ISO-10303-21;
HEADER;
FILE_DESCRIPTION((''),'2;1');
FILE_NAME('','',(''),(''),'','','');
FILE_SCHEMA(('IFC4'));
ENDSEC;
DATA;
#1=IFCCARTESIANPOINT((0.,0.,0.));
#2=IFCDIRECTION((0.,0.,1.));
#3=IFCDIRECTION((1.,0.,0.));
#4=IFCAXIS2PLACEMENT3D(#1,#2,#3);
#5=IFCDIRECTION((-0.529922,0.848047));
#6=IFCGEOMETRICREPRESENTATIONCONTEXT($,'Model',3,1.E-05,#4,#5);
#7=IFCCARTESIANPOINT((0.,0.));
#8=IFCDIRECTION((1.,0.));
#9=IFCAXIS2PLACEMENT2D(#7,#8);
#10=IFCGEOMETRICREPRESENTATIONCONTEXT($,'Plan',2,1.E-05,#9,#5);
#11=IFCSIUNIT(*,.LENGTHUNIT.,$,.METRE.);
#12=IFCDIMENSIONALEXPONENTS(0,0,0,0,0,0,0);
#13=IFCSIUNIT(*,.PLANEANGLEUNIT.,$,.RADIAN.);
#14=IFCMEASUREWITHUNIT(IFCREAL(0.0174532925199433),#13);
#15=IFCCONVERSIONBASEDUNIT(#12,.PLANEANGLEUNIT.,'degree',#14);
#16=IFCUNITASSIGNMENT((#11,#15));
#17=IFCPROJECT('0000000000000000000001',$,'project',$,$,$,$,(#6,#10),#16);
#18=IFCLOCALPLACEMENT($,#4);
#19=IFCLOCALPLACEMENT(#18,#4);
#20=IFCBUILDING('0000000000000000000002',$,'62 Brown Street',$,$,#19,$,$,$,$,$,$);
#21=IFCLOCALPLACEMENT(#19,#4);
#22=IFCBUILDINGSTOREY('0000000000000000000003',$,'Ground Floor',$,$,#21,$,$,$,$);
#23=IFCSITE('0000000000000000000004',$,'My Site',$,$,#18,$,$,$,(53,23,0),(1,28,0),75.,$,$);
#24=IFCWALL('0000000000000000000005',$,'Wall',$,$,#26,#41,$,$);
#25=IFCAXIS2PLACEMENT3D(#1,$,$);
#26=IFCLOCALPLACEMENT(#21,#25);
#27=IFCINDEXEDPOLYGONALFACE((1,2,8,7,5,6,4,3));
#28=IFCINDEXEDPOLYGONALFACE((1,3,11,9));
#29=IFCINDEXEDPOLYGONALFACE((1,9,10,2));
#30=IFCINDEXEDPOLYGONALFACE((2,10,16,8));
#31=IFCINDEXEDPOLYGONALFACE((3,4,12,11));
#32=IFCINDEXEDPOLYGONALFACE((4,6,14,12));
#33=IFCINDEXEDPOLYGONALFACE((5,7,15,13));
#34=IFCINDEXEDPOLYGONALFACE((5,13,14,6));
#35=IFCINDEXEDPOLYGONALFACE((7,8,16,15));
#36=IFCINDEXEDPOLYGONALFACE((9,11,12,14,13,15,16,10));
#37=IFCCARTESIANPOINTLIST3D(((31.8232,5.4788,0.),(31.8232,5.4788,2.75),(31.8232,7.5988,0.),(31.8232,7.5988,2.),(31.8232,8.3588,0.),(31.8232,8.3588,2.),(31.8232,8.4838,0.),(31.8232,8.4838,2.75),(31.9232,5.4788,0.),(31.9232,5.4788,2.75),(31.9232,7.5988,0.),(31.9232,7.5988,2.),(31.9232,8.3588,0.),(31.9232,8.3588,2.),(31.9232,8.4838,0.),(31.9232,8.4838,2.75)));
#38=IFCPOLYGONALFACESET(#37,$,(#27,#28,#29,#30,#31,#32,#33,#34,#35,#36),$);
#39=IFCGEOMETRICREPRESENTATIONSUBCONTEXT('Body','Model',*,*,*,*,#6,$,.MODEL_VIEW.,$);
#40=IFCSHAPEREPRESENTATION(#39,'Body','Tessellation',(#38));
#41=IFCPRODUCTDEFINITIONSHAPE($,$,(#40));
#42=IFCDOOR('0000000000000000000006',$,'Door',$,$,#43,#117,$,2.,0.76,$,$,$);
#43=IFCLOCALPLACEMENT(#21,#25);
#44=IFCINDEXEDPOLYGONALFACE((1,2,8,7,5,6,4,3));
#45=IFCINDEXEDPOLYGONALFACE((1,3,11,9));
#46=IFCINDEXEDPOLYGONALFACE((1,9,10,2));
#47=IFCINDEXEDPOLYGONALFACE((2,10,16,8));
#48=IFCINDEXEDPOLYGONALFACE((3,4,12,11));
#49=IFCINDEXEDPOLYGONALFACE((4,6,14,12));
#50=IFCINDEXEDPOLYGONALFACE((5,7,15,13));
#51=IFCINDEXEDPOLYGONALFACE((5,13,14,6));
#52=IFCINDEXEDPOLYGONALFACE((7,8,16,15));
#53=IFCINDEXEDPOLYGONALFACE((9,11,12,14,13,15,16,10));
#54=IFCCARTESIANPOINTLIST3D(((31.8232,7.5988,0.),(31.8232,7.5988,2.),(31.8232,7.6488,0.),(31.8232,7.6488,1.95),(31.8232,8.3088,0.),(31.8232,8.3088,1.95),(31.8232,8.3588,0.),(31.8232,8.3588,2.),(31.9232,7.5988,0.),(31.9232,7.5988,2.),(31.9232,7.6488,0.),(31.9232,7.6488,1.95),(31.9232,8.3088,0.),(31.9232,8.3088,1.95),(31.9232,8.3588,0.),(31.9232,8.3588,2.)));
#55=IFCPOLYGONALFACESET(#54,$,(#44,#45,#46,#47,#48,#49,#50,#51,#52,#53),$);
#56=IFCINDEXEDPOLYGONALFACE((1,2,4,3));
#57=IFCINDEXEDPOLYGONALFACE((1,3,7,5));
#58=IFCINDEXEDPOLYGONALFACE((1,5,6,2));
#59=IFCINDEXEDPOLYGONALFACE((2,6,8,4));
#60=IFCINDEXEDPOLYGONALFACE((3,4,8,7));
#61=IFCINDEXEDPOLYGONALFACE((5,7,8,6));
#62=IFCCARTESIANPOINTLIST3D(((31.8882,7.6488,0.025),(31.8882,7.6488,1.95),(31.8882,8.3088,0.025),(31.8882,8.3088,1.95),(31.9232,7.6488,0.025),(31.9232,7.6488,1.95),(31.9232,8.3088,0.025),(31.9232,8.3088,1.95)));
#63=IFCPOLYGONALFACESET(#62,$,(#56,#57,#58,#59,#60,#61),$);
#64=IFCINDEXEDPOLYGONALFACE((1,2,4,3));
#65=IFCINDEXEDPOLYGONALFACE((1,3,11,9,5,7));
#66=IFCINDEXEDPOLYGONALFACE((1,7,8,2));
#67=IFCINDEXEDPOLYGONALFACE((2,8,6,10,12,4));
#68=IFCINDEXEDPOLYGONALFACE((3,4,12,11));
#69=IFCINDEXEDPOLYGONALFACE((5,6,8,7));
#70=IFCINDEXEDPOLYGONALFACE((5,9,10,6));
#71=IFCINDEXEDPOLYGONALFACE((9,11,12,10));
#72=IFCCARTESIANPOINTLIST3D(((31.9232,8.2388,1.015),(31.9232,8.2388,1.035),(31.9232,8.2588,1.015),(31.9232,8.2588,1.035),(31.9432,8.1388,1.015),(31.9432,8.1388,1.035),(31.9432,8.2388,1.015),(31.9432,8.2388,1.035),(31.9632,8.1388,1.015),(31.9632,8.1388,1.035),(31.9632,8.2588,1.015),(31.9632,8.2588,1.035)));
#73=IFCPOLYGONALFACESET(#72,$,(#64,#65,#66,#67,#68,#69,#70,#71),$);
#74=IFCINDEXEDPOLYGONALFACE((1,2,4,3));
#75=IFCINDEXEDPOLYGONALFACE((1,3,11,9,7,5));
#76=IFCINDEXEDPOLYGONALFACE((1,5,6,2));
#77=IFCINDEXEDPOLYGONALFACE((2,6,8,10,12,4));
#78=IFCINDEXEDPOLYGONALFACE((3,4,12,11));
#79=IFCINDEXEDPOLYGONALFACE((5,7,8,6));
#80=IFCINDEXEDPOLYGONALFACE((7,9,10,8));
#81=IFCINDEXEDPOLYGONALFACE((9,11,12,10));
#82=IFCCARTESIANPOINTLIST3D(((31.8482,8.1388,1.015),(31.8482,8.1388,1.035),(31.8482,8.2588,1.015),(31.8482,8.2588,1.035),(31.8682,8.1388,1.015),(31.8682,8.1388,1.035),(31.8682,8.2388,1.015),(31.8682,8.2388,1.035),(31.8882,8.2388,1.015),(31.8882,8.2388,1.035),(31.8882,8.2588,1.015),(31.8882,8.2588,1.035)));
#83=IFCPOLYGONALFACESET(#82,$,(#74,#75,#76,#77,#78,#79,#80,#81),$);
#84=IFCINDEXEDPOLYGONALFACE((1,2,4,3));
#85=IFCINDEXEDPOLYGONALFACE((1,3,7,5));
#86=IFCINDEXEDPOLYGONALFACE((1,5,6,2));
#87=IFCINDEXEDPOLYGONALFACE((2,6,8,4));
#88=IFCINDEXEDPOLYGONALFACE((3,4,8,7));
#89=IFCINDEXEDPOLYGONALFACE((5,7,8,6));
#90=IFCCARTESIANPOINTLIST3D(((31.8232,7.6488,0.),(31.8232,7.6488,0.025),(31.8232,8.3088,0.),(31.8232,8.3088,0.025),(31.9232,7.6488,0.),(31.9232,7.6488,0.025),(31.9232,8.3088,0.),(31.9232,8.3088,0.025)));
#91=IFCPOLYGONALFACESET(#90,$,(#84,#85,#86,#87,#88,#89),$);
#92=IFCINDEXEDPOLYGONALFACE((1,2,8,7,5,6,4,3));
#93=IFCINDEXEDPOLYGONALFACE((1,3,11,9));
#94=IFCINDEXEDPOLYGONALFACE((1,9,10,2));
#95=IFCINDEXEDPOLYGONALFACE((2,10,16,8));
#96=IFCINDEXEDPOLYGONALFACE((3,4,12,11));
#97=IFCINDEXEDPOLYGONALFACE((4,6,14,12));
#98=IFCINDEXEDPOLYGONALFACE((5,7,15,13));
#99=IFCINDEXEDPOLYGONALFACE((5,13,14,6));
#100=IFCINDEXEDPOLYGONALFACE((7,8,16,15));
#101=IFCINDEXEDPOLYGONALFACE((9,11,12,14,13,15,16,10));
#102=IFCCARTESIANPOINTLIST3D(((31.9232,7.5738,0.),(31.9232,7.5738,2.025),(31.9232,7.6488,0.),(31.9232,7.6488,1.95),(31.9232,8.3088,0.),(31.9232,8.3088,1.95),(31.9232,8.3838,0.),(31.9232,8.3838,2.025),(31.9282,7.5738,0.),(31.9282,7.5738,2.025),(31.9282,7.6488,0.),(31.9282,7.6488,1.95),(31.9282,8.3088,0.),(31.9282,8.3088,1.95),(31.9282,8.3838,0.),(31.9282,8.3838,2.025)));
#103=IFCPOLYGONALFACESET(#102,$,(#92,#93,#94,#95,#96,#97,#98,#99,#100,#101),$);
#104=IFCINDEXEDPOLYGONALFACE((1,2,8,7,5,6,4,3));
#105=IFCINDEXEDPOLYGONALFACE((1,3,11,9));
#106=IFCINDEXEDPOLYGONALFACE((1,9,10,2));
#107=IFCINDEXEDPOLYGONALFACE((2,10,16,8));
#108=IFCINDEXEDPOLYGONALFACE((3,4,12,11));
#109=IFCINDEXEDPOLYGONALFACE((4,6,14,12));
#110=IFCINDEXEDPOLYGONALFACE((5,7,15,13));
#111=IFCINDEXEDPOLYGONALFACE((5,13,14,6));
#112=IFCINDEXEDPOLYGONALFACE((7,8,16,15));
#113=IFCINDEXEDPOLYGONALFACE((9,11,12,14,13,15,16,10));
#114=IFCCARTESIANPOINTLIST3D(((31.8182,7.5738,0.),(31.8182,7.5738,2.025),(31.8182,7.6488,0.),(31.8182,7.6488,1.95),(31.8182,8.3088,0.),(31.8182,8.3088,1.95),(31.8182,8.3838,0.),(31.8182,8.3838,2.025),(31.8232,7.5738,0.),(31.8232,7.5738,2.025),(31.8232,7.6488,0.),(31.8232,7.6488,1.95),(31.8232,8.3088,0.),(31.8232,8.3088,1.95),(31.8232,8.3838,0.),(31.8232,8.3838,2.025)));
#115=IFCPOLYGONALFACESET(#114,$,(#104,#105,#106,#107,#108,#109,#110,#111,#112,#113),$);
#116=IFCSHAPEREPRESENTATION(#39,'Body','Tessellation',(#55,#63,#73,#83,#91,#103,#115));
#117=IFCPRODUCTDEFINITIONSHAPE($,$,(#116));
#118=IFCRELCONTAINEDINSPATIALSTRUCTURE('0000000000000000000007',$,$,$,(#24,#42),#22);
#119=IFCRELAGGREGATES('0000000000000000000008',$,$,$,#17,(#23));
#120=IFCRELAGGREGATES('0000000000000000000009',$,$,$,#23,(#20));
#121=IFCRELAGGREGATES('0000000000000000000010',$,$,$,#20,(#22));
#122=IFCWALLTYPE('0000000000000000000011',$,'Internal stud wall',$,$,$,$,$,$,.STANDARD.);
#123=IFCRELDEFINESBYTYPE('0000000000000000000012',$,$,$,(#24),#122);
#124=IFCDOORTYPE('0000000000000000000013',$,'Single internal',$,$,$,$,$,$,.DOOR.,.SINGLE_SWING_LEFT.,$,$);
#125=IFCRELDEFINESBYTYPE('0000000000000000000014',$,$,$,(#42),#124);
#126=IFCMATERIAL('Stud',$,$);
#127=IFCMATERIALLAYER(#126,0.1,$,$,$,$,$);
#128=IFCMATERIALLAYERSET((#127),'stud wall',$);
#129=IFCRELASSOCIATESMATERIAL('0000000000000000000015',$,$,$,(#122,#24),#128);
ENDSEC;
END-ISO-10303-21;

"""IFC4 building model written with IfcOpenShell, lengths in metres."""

from ifc_helpers import new_model, entity, si_unit, converted_unit, direction, frame, origin_with_axes, origin_2d_with_axis, place, context, subcontext, project, spatial, line, indexed_curve, outline, extrude, shape, source, transform, mapped, material, layer, layer_set, layer_usage, type_object, type_shapes, element, fill, save


model = new_model("IFC4")

# Units and contexts
model_context = context("Model", 3, precision=1e-05, world=origin_with_axes(), true_north=direction((-0.529922, 0.848047)))
plan_context = context("Plan", 2, precision=1e-05, world=origin_2d_with_axis(), true_north=direction((-0.529922, 0.848047)))
body_context_1 = subcontext(model_context, "Body", "Model", "MODEL_VIEW")
body_context_2 = subcontext(plan_context, "Body", "Plan", "PLAN_VIEW")
ifc_project = project(units=[si_unit("LENGTHUNIT", "METRE"), converted_unit("PLANEANGLEUNIT", "degree", entity("IfcReal", 0.0174532925199433), si_unit("PLANEANGLEUNIT", "RADIAN"), dimensions=[0, 0, 0, 0, 0, 0, 0])], contexts=[model_context, plan_context])

# Site, building, storey
site_placement = place(None, origin_with_axes())
site = spatial("IfcSite", under=ifc_project, at=site_placement, Name="My Site", RefLatitude=(53, 23, 0), RefLongitude=(1, 28, 0), RefElevation=75.0)
building_placement = place(site_placement, origin_with_axes())
building = spatial("IfcBuilding", under=site, at=building_placement, Name="62 Brown Street")
storey_placement = place(building_placement, origin_with_axes())
storey = spatial("IfcBuildingStorey", under=building, at=storey_placement, Name="Ground Floor")

# Wall, opening, door
ifc_material_1 = material(Name="Stud")
ifc_layer_1 = layer(ifc_material_1, 0.1)
ifc_layer_set_1 = layer_set([ifc_layer_1], Name="stud wall")
wall_type_1 = type_object("IfcWallType", Name="Internal stud wall", PredefinedType="STANDARD", material=ifc_layer_set_1)
shared_shape_1 = source(origin_with_axes(), body_context_1, "Body", "SweptSolid", [
    extrude(outline(indexed_curve([(0.0, 0.0), (0.76, 0.0), (0.76, 2.0), (0.0, 2.0)], segments=[line(1, 2, 3, 4, 1)])), frame((0.0, -0.6, 0.0), z_axis=(0.0, -1.0, 0.0), x_axis=(1.0, 0.0, 0.0)), (0.0, 0.0, -1.0), 1.2),
])
door_type_1 = type_object("IfcDoorType", Name="Single internal", OperationType="SINGLE_SWING_LEFT", PredefinedType="DOOR")
shared_shape_2 = source(origin_with_axes(), body_context_1, "Body", "SweptSolid", [
    extrude(outline(indexed_curve([(0.0, 0.0), (0.0, 2.0), (0.76, 2.0), (0.76, 0.0), (0.71, 0.0), (0.71, 1.95), (0.05, 1.95), (0.05, 0.0)], segments=[line(1, 2, 3, 4, 5, 6, 7, 8, 1)])), frame((0.0, 0.0, 0.0), z_axis=(0.0, -1.0, 0.0), x_axis=(1.0, 0.0, 0.0)), (0.0, 0.0, -1.0), 0.1),
    extrude(outline(indexed_curve([(0.0, 0.0), (0.66, 0.0), (0.66, 0.035), (0.0, 0.035)], segments=[line(1, 2, 3, 4, 1)])), frame((0.05, 0.0, 0.025), z_axis=(0.0, 0.0, 1.0), x_axis=(1.0, 0.0, 0.0)), (0.0, 0.0, 1.0), 1.925),
    extrude(outline(indexed_curve([(0.0, 0.0), (0.0, -0.04), (-0.12, -0.04), (-0.12, -0.02), (-0.02, -0.02), (-0.02, 0.0)], segments=[line(1, 2, 3, 4, 5, 6, 1)])), frame((0.66, 0.0, 1.015), z_axis=(0.0, 0.0, 1.0), x_axis=(1.0, 0.0, 0.0)), (0.0, 0.0, 1.0), 0.02),
    extrude(outline(indexed_curve([(0.0, 0.0), (0.0, 0.04), (-0.12, 0.04), (-0.12, 0.02), (-0.02, 0.02), (-0.02, 0.0)], segments=[line(1, 2, 3, 4, 5, 6, 1)])), frame((0.66, 0.035, 1.015), z_axis=(0.0, 0.0, 1.0), x_axis=(1.0, 0.0, 0.0)), (0.0, 0.0, 1.0), 0.02),
    extrude(outline(indexed_curve([(0.0, 0.0), (0.66, 0.0), (0.66, 0.1), (0.0, 0.1)], segments=[line(1, 2, 3, 4, 1)])), frame((0.05, 0.0, 0.0), z_axis=(0.0, 0.0, 1.0), x_axis=(1.0, 0.0, 0.0)), (0.0, 0.0, 1.0), 0.025),
    extrude(outline(indexed_curve([(0.0, 0.0), (0.0, 2.025), (0.81, 2.025), (0.81, 0.0), (0.735, 0.0), (0.735, 1.95), (0.075, 1.95), (0.075, 0.0)], segments=[line(1, 2, 3, 4, 5, 6, 7, 8, 1)])), frame((-0.025, -0.005, 0.0), z_axis=(0.0, -1.0, 0.0), x_axis=(1.0, 0.0, 0.0)), (0.0, 0.0, -1.0), 0.005),
    extrude(outline(indexed_curve([(0.0, 0.0), (0.0, 2.025), (0.81, 2.025), (0.81, 0.0), (0.735, 0.0), (0.735, 1.95), (0.075, 1.95), (0.075, 0.0)], segments=[line(1, 2, 3, 4, 5, 6, 7, 8, 1)])), frame((-0.025, 0.1, 0.0), z_axis=(0.0, -1.0, 0.0), x_axis=(1.0, 0.0, 0.0)), (0.0, 0.0, -1.0), 0.005),
])
shared_shape_3 = source(origin_with_axes(), body_context_2, "Body", "Curve2D", [
    entity("IfcIndexedPolyCurve", entity("IfcCartesianPointList2D", [[0.0, 0.0], [0.05, 0.0], [0.05, 0.1], [0.0, 0.1]]), [entity("IfcLineIndex", [1, 2, 3, 4, 1])]),
    entity("IfcIndexedPolyCurve", entity("IfcCartesianPointList2D", [[0.76, 0.0], [0.71, 0.0], [0.71, 0.1], [0.76, 0.1]]), [entity("IfcLineIndex", [1, 2, 3, 4, 1])]),
    entity("IfcTrimmedCurve", entity("IfcEllipse", entity("IfcAxis2Placement2D", entity("IfcCartesianPoint", [0.085, 0.1]), entity("IfcDirection", [1.0, 0.0])), 0.625, 0.66), [entity("IfcCartesianPoint", [0.71, 0.1])], [entity("IfcCartesianPoint", [0.085, 0.76])], True, "CARTESIAN"),
    entity("IfcIndexedPolyCurve", entity("IfcCartesianPointList2D", [[0.05, 0.1], [0.085, 0.1], [0.085, 0.76], [0.05, 0.76]]), [entity("IfcLineIndex", [1, 2, 3, 4, 1])]),
])
type_shapes(door_type_1, [shared_shape_2, shared_shape_3])
ifc_layer_usage_1 = layer_usage(ifc_layer_set_1, "AXIS2", "POSITIVE", 0.0)
wall_1_placement = place(storey_placement, frame((31.9232, 5.4788, 0.0), z_axis=(0.0, 0.0, 1.0), x_axis=(0.000001, 1.0, 0.0)))
wall_1 = element("IfcWall", 1, at=wall_1_placement, inside=storey, type_object=wall_type_1, material=ifc_layer_usage_1, Name="Wall", context=body_context_1, shape_type="SweptSolid", body=[
    extrude(outline(indexed_curve([(0.0, 0.0), (0.0, 0.1), (3.005, 0.1), (3.005, 0.0), (0.0, 0.0)], self_intersect=False)), origin_with_axes(), (0.0, 0.0, 1.0), 2.75),
])
opening_1_placement = place(wall_1_placement, frame((2.12, 0.0, 0.0), z_axis=(0.0, 0.0, 1.0), x_axis=(1.0, 0.0, 0.0)))
opening_1 = element("IfcOpeningElement", 2, at=opening_1_placement, cuts=wall_1, PredefinedType="OPENING", context=body_context_1, shape_type="MappedRepresentation", body=[
    mapped(shared_shape_1, transform((0.0, 0.0, 0.0), x_axis=(1.0, 0.0, 0.0), y_axis=(0.0, 1.0, 0.0), z_axis=(0.0, 0.0, 1.0), scale=1.0)),
])
door_1_placement = place(opening_1_placement, frame((0.0, 0.0, 0.0), z_axis=(0.0, 0.0, 1.0), x_axis=(1.0, 0.0, 0.0)))
door_1 = element("IfcDoor", 3, at=door_1_placement, inside=storey, type_object=door_type_1, Name="Door", OverallHeight=2.0, OverallWidth=0.76, shapes=[
    shape(body_context_1, "Body", "MappedRepresentation", [mapped(shared_shape_2, transform((0.0, 0.0, 0.0), x_axis=(1.0, 0.0, 0.0), y_axis=(0.0, 1.0, 0.0), z_axis=(0.0, 0.0, 1.0), scale=1.0))]),
    shape(body_context_2, "Body", "MappedRepresentation", [mapped(shared_shape_3, transform((0.0, 0.0, 0.0), x_axis=(1.0, 0.0, 0.0), y_axis=(0.0, 1.0, 0.0), z_axis=(0.0, 0.0, 1.0), scale=1.0))]),
])
fill(opening_1, door_1)

save(model, "model.ifc")
